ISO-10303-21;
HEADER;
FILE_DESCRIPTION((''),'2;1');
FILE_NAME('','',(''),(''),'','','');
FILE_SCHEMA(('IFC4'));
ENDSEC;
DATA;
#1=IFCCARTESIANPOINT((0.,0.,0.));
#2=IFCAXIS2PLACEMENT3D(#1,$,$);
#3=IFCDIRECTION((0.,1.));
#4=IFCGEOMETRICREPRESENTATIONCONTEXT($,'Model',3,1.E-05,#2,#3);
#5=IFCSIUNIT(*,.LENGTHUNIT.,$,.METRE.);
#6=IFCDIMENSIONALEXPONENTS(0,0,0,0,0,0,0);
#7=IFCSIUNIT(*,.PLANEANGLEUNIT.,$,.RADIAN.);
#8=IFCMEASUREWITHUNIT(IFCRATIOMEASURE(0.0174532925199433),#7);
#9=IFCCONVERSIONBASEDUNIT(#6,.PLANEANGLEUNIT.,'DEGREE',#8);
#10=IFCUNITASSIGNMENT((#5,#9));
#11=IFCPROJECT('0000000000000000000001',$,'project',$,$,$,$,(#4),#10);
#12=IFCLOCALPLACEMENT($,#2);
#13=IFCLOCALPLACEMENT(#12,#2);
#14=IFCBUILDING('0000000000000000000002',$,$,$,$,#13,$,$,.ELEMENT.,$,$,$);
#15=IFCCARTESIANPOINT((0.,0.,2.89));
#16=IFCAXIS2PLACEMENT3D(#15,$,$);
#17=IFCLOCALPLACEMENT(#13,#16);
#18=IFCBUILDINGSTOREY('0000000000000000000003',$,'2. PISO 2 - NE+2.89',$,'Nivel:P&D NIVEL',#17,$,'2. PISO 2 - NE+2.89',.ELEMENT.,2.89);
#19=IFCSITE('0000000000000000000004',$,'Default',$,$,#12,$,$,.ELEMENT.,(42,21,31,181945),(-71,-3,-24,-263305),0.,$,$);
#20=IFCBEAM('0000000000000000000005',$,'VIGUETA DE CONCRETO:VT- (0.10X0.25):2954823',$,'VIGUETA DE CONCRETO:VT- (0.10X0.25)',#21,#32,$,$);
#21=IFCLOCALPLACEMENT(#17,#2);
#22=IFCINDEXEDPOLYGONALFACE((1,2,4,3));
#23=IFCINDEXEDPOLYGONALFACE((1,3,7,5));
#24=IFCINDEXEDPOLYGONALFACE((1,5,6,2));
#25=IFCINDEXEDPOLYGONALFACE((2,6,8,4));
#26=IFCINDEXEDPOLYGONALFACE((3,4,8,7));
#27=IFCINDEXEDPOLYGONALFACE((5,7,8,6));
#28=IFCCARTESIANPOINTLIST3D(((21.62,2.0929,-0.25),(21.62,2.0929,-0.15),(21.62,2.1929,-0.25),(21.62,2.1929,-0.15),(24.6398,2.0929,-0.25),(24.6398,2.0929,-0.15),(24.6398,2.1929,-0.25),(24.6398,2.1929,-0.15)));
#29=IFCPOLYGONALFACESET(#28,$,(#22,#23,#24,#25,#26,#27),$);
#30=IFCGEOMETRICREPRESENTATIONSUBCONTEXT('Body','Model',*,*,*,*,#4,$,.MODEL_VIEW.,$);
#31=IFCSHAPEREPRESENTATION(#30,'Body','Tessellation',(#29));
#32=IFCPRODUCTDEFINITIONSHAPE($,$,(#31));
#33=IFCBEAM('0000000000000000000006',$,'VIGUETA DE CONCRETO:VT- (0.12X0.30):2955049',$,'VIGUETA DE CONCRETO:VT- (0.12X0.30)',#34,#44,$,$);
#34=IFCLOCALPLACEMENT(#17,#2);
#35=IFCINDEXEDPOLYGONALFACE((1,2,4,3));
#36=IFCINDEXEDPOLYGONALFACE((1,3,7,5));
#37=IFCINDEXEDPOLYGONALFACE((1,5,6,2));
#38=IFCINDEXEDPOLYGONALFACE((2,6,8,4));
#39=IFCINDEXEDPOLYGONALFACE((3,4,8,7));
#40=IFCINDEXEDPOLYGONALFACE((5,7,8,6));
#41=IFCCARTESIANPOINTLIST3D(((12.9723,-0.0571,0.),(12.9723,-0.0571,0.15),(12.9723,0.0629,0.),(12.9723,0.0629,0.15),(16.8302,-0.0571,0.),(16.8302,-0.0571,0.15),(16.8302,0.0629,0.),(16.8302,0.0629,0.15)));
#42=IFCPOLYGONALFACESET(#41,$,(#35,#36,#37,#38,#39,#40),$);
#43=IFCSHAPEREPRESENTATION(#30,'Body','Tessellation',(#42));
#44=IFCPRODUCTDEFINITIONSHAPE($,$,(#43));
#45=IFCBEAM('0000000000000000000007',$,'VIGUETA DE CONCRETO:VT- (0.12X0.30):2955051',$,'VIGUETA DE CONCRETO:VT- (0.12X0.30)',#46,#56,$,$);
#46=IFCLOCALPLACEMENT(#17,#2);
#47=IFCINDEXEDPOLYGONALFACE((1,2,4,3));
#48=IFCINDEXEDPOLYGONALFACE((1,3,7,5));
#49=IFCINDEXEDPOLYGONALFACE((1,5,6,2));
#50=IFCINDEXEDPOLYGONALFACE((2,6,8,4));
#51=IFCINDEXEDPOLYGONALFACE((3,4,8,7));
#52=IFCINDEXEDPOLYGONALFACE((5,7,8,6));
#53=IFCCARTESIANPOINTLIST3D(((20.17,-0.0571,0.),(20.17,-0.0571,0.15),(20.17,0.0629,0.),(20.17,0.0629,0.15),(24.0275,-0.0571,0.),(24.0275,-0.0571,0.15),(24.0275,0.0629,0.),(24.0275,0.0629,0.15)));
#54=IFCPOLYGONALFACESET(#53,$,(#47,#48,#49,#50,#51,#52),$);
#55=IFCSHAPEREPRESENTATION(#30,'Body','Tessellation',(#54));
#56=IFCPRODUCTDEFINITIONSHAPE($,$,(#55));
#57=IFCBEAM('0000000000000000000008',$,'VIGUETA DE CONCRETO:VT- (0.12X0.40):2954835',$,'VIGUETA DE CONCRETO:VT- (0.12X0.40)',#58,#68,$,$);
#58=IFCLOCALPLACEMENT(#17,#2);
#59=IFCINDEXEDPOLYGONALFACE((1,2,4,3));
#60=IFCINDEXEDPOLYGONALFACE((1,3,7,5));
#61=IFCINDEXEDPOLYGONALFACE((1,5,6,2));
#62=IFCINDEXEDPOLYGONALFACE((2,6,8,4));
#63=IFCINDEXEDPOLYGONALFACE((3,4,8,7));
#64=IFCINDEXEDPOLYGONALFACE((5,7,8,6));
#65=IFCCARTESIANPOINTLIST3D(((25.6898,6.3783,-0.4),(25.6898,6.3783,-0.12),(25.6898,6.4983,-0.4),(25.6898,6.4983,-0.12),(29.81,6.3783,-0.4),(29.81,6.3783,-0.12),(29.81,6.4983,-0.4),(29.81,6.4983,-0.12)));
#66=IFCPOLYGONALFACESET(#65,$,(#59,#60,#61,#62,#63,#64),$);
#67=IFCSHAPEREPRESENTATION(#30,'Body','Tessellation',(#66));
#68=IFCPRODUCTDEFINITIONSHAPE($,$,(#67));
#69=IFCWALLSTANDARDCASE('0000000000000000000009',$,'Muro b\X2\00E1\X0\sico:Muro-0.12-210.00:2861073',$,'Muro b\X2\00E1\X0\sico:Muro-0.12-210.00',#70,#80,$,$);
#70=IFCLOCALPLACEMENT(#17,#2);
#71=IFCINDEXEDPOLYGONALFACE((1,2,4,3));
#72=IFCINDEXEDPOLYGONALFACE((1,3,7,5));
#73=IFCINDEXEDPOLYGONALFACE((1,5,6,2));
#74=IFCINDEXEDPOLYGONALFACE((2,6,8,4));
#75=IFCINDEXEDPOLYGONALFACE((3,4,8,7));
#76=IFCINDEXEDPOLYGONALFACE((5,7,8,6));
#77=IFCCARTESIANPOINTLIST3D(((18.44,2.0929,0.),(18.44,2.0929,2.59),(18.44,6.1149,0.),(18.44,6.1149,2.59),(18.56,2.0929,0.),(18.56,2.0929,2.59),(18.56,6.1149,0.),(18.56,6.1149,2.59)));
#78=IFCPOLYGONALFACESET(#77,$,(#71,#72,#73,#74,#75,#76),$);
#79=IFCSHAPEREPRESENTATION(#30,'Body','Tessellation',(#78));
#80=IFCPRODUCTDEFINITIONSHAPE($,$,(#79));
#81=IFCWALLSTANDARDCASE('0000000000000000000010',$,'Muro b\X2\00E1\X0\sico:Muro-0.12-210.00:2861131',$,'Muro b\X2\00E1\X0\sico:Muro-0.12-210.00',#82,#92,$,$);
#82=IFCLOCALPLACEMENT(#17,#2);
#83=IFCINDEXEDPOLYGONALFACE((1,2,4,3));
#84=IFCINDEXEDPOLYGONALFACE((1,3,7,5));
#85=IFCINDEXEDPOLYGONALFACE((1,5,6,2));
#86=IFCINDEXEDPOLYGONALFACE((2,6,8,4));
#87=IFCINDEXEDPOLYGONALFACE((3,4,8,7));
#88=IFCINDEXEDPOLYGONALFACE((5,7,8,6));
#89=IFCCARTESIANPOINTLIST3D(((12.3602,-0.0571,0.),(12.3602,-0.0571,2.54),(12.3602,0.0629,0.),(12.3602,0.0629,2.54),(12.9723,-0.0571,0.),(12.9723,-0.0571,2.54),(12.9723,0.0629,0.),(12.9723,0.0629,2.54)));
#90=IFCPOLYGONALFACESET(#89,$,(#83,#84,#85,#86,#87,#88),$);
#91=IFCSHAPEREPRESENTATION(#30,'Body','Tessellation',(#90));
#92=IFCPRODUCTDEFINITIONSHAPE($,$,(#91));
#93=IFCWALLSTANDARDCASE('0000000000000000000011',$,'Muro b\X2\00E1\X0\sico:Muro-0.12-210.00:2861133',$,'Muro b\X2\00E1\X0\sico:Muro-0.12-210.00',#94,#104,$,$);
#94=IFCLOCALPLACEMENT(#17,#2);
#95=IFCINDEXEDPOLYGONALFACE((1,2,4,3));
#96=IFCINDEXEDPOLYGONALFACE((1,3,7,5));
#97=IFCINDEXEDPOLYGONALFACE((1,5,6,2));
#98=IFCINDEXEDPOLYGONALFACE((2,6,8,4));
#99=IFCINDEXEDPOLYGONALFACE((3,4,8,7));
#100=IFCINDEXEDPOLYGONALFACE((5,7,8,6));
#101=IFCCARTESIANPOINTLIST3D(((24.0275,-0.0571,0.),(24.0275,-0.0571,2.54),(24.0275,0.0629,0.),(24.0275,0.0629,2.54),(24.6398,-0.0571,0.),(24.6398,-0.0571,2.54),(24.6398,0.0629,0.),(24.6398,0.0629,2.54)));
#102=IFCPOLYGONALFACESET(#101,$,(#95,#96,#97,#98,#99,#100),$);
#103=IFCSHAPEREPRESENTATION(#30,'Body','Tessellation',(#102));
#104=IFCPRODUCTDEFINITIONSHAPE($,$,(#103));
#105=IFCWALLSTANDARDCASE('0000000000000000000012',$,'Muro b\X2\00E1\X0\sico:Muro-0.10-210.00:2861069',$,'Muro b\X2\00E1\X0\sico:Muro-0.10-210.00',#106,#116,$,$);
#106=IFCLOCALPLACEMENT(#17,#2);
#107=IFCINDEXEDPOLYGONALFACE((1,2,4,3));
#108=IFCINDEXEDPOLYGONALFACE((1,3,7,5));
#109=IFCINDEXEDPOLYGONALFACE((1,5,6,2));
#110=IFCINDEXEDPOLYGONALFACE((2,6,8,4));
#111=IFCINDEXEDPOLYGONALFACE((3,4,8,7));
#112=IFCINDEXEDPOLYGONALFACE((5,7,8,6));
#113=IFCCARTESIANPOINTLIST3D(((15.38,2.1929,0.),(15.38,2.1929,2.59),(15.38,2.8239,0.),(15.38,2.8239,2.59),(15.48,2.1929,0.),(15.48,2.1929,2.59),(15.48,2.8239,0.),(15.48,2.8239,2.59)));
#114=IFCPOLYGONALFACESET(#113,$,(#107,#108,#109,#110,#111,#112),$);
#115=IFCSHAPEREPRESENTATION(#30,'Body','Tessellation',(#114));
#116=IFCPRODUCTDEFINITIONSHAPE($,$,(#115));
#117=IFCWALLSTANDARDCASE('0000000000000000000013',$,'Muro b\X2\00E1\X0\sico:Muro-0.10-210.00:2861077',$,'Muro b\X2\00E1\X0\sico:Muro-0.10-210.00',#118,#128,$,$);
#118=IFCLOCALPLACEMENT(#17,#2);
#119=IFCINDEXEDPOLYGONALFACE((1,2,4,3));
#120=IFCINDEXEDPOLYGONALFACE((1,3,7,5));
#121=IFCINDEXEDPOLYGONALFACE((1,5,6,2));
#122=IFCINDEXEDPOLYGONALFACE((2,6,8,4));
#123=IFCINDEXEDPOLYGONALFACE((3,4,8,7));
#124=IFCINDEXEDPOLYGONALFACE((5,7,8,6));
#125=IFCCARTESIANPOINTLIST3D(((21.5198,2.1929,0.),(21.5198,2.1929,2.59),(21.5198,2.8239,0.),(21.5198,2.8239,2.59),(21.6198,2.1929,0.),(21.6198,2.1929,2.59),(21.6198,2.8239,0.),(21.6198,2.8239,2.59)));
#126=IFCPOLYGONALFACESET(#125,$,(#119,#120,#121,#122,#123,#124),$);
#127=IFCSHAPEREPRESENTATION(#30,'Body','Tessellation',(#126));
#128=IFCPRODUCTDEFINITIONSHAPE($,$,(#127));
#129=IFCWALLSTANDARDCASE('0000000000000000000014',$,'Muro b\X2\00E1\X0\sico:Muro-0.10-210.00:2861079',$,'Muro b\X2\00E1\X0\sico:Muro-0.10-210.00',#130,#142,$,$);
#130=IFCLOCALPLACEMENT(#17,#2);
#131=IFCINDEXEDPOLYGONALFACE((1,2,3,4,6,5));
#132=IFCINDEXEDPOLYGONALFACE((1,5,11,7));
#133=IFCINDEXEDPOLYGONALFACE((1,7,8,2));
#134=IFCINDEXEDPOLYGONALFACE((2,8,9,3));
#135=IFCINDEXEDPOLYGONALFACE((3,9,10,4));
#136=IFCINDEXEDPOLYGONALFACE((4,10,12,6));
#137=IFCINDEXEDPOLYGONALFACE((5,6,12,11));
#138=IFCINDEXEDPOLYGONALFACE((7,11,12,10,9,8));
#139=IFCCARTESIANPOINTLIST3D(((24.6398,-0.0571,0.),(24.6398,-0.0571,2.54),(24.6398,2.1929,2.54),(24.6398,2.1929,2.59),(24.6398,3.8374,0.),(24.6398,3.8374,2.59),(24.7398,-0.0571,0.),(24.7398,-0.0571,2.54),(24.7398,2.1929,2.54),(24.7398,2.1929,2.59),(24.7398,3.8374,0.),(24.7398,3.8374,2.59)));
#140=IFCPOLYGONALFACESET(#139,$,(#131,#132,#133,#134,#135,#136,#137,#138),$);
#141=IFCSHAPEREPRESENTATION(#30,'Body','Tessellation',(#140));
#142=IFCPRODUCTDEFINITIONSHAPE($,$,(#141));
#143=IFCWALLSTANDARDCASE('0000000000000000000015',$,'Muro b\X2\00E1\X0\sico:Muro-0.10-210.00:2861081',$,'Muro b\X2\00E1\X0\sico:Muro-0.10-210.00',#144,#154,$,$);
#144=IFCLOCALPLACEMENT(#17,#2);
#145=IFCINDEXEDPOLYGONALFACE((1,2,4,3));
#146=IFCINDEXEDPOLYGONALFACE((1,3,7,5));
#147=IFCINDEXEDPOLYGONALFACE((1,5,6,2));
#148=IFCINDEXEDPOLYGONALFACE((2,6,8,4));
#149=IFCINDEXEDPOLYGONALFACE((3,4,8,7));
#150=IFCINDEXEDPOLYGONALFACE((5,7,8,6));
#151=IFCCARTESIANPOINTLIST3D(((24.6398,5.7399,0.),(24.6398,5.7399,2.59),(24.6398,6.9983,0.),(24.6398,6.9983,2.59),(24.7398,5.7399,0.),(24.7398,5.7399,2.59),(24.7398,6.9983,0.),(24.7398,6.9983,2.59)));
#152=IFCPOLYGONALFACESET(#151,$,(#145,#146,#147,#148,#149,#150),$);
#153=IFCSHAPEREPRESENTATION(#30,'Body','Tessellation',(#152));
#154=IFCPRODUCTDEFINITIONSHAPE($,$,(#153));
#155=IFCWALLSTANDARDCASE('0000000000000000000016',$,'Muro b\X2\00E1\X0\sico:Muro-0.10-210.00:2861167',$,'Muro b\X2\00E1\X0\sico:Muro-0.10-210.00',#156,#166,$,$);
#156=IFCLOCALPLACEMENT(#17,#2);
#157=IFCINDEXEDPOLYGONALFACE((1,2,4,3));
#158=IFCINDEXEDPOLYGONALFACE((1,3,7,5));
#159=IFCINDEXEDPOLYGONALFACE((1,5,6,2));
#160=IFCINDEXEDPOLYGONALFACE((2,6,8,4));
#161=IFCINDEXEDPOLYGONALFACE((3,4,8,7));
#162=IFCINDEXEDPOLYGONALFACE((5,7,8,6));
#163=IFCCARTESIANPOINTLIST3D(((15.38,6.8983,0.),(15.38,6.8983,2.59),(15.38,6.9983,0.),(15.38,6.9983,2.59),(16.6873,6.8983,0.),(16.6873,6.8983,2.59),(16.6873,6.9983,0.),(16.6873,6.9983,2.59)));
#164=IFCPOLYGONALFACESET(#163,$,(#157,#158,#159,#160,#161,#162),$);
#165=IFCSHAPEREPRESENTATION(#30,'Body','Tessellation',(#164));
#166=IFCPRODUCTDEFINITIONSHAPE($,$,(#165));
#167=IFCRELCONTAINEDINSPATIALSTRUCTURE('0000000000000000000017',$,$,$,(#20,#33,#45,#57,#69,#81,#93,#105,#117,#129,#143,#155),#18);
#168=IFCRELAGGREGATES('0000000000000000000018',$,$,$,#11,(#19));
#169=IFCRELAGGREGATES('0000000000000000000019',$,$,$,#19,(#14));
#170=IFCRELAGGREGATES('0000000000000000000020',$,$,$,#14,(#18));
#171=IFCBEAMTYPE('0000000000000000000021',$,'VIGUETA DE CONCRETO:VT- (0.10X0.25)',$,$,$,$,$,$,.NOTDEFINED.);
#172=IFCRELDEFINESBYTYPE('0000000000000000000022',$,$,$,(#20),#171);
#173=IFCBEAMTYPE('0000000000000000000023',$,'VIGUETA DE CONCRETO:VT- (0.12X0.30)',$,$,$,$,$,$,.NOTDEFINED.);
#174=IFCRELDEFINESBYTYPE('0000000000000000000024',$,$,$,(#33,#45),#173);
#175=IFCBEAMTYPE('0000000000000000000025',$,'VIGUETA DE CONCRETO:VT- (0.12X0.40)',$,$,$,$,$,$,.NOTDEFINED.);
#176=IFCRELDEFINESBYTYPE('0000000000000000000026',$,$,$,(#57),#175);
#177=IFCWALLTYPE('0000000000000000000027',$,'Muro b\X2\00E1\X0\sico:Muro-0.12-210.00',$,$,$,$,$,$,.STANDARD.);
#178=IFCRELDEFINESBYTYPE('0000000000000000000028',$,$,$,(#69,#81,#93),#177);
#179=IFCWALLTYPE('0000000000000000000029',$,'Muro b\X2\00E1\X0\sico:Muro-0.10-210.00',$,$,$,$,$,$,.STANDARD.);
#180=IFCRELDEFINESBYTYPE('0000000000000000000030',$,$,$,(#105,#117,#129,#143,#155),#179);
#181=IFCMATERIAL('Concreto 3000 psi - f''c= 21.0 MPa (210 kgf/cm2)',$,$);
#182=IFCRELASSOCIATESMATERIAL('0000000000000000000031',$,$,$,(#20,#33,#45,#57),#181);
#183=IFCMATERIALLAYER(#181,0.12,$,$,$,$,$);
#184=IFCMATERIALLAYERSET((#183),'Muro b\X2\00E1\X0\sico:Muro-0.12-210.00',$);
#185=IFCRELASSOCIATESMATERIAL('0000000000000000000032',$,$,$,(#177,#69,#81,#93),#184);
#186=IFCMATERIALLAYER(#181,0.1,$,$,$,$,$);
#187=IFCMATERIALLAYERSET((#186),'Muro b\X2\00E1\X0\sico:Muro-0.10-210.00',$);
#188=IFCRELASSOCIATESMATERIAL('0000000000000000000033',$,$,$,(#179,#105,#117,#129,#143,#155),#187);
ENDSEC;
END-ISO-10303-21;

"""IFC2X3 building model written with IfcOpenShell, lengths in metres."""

from ifc_helpers import new_model, entity, si_unit, converted_unit, direction, frame, frame_2d, origin, origin_2d_with_axis, place, context, subcontext, project, spatial, polyline, rectangle, extrude, clip, bounded_halfspace, material, layer, layer_set, layer_usage, type_object, element, save


model = new_model("IFC2X3")

# Units and contexts
model_context = context("Model", 3, precision=1e-05, world=origin(), true_north=direction((0.0, 1.0)))
body_context = subcontext(model_context, "Body", "Model", "MODEL_VIEW")
ifc_project = project(units=[si_unit("LENGTHUNIT", "METRE"), converted_unit("PLANEANGLEUNIT", "DEGREE", entity("IfcRatioMeasure", 0.0174532925199433), si_unit("PLANEANGLEUNIT", "RADIAN"), dimensions=[0, 0, 0, 0, 0, 0, 0])], contexts=[model_context])

# Site, building, storey
site_placement = place(None, origin())
site = spatial("IfcSite", under=ifc_project, at=site_placement, Name="Default", CompositionType="ELEMENT", RefLatitude=(42, 21, 31, 181945), RefLongitude=(-71, -3, -24, -263305), RefElevation=0.0)
building_placement = place(site_placement, origin())
building = spatial("IfcBuilding", under=site, at=building_placement, CompositionType="ELEMENT")
storey_placement = place(building_placement, frame((0.0, 0.0, 2.89)))
storey = spatial("IfcBuildingStorey", under=building, at=storey_placement, Name="2. PISO 2 - NE+2.89", ObjectType="Nivel:P&D NIVEL", LongName="2. PISO 2 - NE+2.89", CompositionType="ELEMENT", Elevation=2.89)

# Beams
ifc_material = material(Name="Concreto 3000 psi - f'c= 21.0 MPa (210 kgf/cm2)")
beam_type_1 = type_object("IfcBeamType", Name="VIGUETA DE CONCRETO:VT- (0.10X0.25)", PredefinedType="NOTDEFINED")
beam_1_placement = place(storey_placement, frame((24.6898, 2.1429, 0.0), z_axis=(0.0, 0.0, 1.0), x_axis=(-1.0, 0.0, 0.0)))
element("IfcBeam", 1, at=beam_1_placement, inside=storey, type_object=beam_type_1, material=ifc_material, Name="VIGUETA DE CONCRETO:VT- (0.10X0.25):2954823", ObjectType="VIGUETA DE CONCRETO:VT- (0.10X0.25)", context=body_context, shape_type="SweptSolid", body=[
    extrude(rectangle(XDim=0.1, YDim=0.1, at=origin_2d_with_axis()), frame((0.05, 0.0, -0.2), z_axis=(1.0, 0.0, 0.0), x_axis=(0.0, 0.0, -1.0)), (0.0, 0.0, 1.0), 3.0198),
])
beam_type_2 = type_object("IfcBeamType", Name="VIGUETA DE CONCRETO:VT- (0.12X0.30)", PredefinedType="NOTDEFINED")
beam_2_placement = place(storey_placement, frame((16.9052, 0.0029, 0.0), z_axis=(0.0, 0.0, 1.0), x_axis=(-1.0, 0.0, 0.0)))
element("IfcBeam", 2, at=beam_2_placement, inside=storey, type_object=beam_type_2, material=ifc_material, Name="VIGUETA DE CONCRETO:VT- (0.12X0.30):2955049", ObjectType="VIGUETA DE CONCRETO:VT- (0.12X0.30)", context=body_context, shape_type="SweptSolid", body=[
    extrude(rectangle(XDim=0.15, YDim=0.12, at=frame_2d((0.0, 0.0), x_axis=(1.0, 0.0))), frame((0.075, 0.0, 0.075), z_axis=(1.0, 0.0, 0.0), x_axis=(0.0, 0.0, -1.0)), (0.0, 0.0, 1.0), 3.8579),
])
beam_3_placement = place(storey_placement, frame((20.095, 0.0029, 0.0)))
element("IfcBeam", 3, at=beam_3_placement, inside=storey, type_object=beam_type_2, material=ifc_material, Name="VIGUETA DE CONCRETO:VT- (0.12X0.30):2955051", ObjectType="VIGUETA DE CONCRETO:VT- (0.12X0.30)", context=body_context, shape_type="SweptSolid", body=[
    extrude(rectangle(XDim=0.15, YDim=0.12, at=frame_2d((0.0, 0.0), x_axis=(1.0, 0.0))), frame((0.075, 0.0, 0.075), z_axis=(1.0, 0.0, 0.0), x_axis=(0.0, 0.0, -1.0)), (0.0, 0.0, 1.0), 3.8575),
])
beam_type_3 = type_object("IfcBeamType", Name="VIGUETA DE CONCRETO:VT- (0.12X0.40)", PredefinedType="NOTDEFINED")
beam_4_placement = place(storey_placement, frame((24.6898, 6.4383, 0.0)))
element("IfcBeam", 4, at=beam_4_placement, inside=storey, type_object=beam_type_3, material=ifc_material, Name="VIGUETA DE CONCRETO:VT- (0.12X0.40):2954835", ObjectType="VIGUETA DE CONCRETO:VT- (0.12X0.40)", context=body_context, shape_type="SweptSolid", body=[
    extrude(rectangle(XDim=0.28, YDim=0.12, at=frame_2d((0.0, 0.0), x_axis=(1.0, 0.0))), frame((1.0, 0.0, -0.26), z_axis=(1.0, 0.0, 0.0), x_axis=(0.0, 0.0, -1.0)), (0.0, 0.0, 1.0), 4.1202),
])

# Walls
ifc_layer_1 = layer(ifc_material, 0.12)
ifc_layer_set_1 = layer_set([ifc_layer_1], Name="Muro básico:Muro-0.12-210.00")
ifc_layer_usage_1 = layer_usage(ifc_layer_set_1, "AXIS2", "POSITIVE", -0.06)
wall_type_1 = type_object("IfcWallType", Name="Muro básico:Muro-0.12-210.00", PredefinedType="STANDARD", material=ifc_layer_set_1)
wall_1_placement = place(storey_placement, frame((18.5, 2.0929, 0.0), z_axis=(0.0, 0.0, 1.0), x_axis=(0.0, 1.0, 0.0)))
element("IfcWallStandardCase", 5, at=wall_1_placement, inside=storey, type_object=wall_type_1, material=ifc_layer_usage_1, Name="Muro básico:Muro-0.12-210.00:2861073", ObjectType="Muro básico:Muro-0.12-210.00", context=body_context, shape_type="SweptSolid", body=[
    extrude(rectangle(XDim=4.022, YDim=0.12, at=frame_2d((2.011, 0.0), x_axis=(-1.0, 0.0))), origin(), (0.0, 0.0, 1.0), 2.59),
])
wall_2_placement = place(storey_placement, frame((12.3602, 0.0029, 0.0)))
element("IfcWallStandardCase", 6, at=wall_2_placement, inside=storey, type_object=wall_type_1, material=ifc_layer_usage_1, Name="Muro básico:Muro-0.12-210.00:2861131", ObjectType="Muro básico:Muro-0.12-210.00", context=body_context, shape_type="SweptSolid", body=[
    extrude(rectangle(XDim=0.6121, YDim=0.12, at=frame_2d((0.306, 0.0), x_axis=(-1.0, 0.0))), origin(), (0.0, 0.0, 1.0), 2.54),
])
wall_3_placement = place(storey_placement, frame((24.0275, 0.0029, 0.0)))
element("IfcWallStandardCase", 7, at=wall_3_placement, inside=storey, type_object=wall_type_1, material=ifc_layer_usage_1, Name="Muro básico:Muro-0.12-210.00:2861133", ObjectType="Muro básico:Muro-0.12-210.00", context=body_context, shape_type="SweptSolid", body=[
    extrude(rectangle(XDim=0.6123, YDim=0.12, at=frame_2d((0.3061, 0.0), x_axis=(-1.0, 0.0))), origin(), (0.0, 0.0, 1.0), 2.54),
])
ifc_layer_2 = layer(ifc_material, 0.1)
ifc_layer_set_2 = layer_set([ifc_layer_2], Name="Muro básico:Muro-0.10-210.00")
ifc_layer_usage_2 = layer_usage(ifc_layer_set_2, "AXIS2", "POSITIVE", -0.05)
wall_type_2 = type_object("IfcWallType", Name="Muro básico:Muro-0.10-210.00", PredefinedType="STANDARD", material=ifc_layer_set_2)
wall_4_placement = place(storey_placement, frame((15.43, 2.1929, 0.0), z_axis=(0.0, 0.0, 1.0), x_axis=(0.0, 1.0, 0.0)))
element("IfcWallStandardCase", 8, at=wall_4_placement, inside=storey, type_object=wall_type_2, material=ifc_layer_usage_2, Name="Muro básico:Muro-0.10-210.00:2861069", ObjectType="Muro básico:Muro-0.10-210.00", context=body_context, shape_type="SweptSolid", body=[
    extrude(rectangle(XDim=0.631, YDim=0.1, at=frame_2d((0.3155, 0.0), x_axis=(-1.0, 0.0))), origin(), (0.0, 0.0, 1.0), 2.59),
])
wall_5_placement = place(storey_placement, frame((21.5698, 2.1929, 0.0), z_axis=(0.0, 0.0, 1.0), x_axis=(0.0, 1.0, 0.0)))
element("IfcWallStandardCase", 9, at=wall_5_placement, inside=storey, type_object=wall_type_2, material=ifc_layer_usage_2, Name="Muro básico:Muro-0.10-210.00:2861077", ObjectType="Muro básico:Muro-0.10-210.00", context=body_context, shape_type="SweptSolid", body=[
    extrude(rectangle(XDim=0.631, YDim=0.1, at=frame_2d((0.3155, 0.0), x_axis=(-1.0, 0.0))), origin(), (0.0, 0.0, 1.0), 2.59),
])
wall_6_placement = place(storey_placement, frame((24.6898, -0.0571, 0.0), z_axis=(0.0, 0.0, 1.0), x_axis=(0.0, 1.0, 0.0)))
element("IfcWallStandardCase", 10, at=wall_6_placement, inside=storey, type_object=wall_type_2, material=ifc_layer_usage_2, Name="Muro básico:Muro-0.10-210.00:2861079", ObjectType="Muro básico:Muro-0.10-210.00", context=body_context, shape_type="Clipping", body=[
    clip(clip(extrude(rectangle(XDim=3.8945, YDim=0.1, at=frame_2d((1.9473, 0.0), x_axis=(-1.0, 0.0))), origin(), (0.0, 0.0, 1.0), 2.59), bounded_halfspace(frame((2.25, -0.05, 2.54), z_axis=(0.0, 0.0, -1.0), x_axis=(0.0, -1.0, 0.0)), True, frame((2.25, -0.05, 2.54), z_axis=(0.0, 0.0, -1.0), x_axis=(0.0, -1.0, 0.0)), polyline([(0.0, 0.0), (0.0, 2.25), (-0.1, 2.25), (-0.1, 2.13), (-0.1, 0.0), (0.0, 0.0)]))), bounded_halfspace(frame((2.25, 0.05, 2.54), z_axis=(1.0, 0.0, 0.0), x_axis=(0.0, 0.0, 1.0)), True, frame((2.25, 0.05, 2.54), z_axis=(1.0, 0.0, 0.0), x_axis=(0.0, 0.0, 1.0)), polyline([(0.0, 0.0), (0.05, 0.0), (0.05, 0.1), (0.0, 0.1), (0.0, 0.0)]))),
])
wall_7_placement = place(storey_placement, frame((24.6898, 5.7399, 0.0), z_axis=(0.0, 0.0, 1.0), x_axis=(0.0, 1.0, 0.0)))
element("IfcWallStandardCase", 11, at=wall_7_placement, inside=storey, type_object=wall_type_2, material=ifc_layer_usage_2, Name="Muro básico:Muro-0.10-210.00:2861081", ObjectType="Muro básico:Muro-0.10-210.00", context=body_context, shape_type="SweptSolid", body=[
    extrude(rectangle(XDim=1.2584, YDim=0.1, at=frame_2d((0.6292, 0.0), x_axis=(-1.0, 0.0))), origin(), (0.0, 0.0, 1.0), 2.59),
])
wall_8_placement = place(storey_placement, frame((15.38, 6.9483, 0.0)))
element("IfcWallStandardCase", 12, at=wall_8_placement, inside=storey, type_object=wall_type_2, material=ifc_layer_usage_2, Name="Muro básico:Muro-0.10-210.00:2861167", ObjectType="Muro básico:Muro-0.10-210.00", context=body_context, shape_type="SweptSolid", body=[
    extrude(rectangle(XDim=1.3073, YDim=0.1, at=frame_2d((0.6536, 0.0), x_axis=(-1.0, 0.0))), origin(), (0.0, 0.0, 1.0), 2.59),
])

save(model, "model.ifc")
